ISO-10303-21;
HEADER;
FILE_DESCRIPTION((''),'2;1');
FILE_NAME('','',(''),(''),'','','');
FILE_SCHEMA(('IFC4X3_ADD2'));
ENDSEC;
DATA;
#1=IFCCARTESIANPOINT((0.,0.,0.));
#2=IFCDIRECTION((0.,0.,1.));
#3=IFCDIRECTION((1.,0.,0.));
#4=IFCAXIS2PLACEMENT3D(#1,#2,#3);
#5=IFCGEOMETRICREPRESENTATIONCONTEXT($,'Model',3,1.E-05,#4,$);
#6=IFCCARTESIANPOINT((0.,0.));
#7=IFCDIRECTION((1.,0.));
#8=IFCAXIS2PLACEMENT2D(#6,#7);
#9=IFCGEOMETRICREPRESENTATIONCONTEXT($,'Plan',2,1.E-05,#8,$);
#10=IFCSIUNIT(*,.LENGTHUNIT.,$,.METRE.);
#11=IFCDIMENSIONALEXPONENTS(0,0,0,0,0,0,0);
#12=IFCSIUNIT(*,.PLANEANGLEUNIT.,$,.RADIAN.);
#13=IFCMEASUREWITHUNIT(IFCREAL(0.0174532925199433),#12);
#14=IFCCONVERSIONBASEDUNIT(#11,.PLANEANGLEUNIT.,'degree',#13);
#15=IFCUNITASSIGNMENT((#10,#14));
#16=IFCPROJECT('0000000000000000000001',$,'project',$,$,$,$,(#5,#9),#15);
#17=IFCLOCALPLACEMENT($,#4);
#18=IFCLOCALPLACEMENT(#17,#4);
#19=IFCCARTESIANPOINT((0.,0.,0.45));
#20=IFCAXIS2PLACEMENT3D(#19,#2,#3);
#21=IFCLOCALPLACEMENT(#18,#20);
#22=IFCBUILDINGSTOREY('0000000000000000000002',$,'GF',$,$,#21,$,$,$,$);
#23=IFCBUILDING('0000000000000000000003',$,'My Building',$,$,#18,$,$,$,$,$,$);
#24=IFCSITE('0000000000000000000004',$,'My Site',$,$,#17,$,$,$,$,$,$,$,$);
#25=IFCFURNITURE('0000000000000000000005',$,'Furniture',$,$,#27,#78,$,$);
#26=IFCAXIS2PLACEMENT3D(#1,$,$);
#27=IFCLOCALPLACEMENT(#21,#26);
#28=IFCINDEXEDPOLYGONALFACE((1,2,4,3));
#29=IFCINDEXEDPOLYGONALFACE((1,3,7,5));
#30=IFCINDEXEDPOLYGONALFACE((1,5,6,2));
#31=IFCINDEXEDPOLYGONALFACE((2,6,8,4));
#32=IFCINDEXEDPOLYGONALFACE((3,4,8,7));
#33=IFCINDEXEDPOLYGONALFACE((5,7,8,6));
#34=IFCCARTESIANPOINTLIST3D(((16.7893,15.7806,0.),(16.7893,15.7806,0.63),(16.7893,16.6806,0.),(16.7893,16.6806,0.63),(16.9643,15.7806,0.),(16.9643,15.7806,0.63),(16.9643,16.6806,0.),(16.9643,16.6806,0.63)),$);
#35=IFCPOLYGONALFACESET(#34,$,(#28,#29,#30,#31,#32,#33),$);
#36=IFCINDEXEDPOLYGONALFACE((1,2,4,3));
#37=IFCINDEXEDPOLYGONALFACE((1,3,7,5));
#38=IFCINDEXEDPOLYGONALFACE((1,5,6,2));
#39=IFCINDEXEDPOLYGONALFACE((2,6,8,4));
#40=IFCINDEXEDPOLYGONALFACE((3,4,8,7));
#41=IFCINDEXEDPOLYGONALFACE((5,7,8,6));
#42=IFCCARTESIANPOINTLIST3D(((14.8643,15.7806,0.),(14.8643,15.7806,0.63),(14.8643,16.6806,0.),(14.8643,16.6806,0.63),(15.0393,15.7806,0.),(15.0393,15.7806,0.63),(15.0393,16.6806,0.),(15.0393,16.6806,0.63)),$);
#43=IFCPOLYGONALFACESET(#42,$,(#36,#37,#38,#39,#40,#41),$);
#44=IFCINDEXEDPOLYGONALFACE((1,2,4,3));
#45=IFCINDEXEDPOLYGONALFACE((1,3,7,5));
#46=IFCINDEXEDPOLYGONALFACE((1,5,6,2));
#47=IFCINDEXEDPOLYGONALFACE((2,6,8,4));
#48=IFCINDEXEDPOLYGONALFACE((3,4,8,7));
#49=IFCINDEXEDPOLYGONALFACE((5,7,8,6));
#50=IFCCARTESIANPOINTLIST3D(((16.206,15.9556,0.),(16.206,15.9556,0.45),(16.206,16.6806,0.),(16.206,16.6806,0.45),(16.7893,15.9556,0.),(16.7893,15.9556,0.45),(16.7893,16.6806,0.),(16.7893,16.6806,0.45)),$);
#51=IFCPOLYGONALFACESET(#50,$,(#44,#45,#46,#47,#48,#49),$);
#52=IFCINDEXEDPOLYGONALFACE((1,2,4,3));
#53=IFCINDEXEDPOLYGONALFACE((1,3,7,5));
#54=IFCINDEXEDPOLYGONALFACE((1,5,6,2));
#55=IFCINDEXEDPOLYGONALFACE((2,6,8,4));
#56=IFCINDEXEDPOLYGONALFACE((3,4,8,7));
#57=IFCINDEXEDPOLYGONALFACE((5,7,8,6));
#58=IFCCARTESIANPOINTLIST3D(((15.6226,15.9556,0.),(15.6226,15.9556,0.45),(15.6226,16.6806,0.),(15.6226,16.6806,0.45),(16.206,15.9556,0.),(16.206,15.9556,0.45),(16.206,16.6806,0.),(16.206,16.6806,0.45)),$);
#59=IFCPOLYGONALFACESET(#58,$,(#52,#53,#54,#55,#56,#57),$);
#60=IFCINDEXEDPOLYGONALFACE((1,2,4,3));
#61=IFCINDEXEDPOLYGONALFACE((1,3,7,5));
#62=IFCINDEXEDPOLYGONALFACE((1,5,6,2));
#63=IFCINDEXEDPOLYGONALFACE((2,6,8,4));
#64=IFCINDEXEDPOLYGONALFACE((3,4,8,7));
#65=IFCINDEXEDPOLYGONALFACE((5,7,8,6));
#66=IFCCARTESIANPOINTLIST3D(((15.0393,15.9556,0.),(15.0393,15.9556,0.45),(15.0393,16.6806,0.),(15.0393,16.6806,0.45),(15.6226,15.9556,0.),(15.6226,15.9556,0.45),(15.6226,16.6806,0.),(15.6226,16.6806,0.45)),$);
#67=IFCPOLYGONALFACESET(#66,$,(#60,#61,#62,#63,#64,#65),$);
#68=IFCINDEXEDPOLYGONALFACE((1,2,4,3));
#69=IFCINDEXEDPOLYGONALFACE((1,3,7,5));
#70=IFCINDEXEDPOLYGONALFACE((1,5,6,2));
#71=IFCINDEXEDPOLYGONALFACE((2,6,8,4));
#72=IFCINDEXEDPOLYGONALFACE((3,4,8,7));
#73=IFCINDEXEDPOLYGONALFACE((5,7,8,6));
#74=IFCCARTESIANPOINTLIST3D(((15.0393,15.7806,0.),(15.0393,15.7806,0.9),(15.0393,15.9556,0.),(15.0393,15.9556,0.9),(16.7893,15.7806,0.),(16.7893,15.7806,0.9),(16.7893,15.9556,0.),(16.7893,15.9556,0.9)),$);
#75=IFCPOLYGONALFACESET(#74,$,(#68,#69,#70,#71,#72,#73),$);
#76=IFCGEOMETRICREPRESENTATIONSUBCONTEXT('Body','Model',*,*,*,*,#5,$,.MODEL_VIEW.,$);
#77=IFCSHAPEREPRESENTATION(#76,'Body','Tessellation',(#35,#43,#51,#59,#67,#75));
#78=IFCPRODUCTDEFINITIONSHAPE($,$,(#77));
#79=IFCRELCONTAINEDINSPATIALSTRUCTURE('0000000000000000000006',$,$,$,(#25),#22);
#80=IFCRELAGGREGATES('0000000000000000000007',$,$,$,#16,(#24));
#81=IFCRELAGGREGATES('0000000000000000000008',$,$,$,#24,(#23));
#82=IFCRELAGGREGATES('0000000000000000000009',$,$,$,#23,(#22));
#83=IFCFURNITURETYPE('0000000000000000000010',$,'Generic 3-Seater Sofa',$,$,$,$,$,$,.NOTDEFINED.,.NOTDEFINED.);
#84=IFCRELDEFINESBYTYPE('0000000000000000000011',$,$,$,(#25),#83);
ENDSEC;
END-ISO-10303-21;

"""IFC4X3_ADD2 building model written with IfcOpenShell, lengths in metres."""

from ifc_helpers import new_model, entity, si_unit, converted_unit, frame, origin_with_axes, origin_2d_with_axis, place, context, subcontext, project, spatial, line, indexed_curve, outline, extrude, shape, source, transform, mapped, type_object, type_shapes, element, save


model = new_model("IFC4X3_ADD2")

# Units and contexts
model_context = context("Model", 3, precision=1e-05, world=origin_with_axes())
plan_context = context("Plan", 2, precision=1e-05, world=origin_2d_with_axis())
body_context_1 = subcontext(model_context, "Body", "Model", "MODEL_VIEW")
body_context_2 = subcontext(plan_context, "Body", "Plan", "PLAN_VIEW")
ifc_project = project(units=[si_unit("LENGTHUNIT", "METRE"), converted_unit("PLANEANGLEUNIT", "degree", entity("IfcReal", 0.0174532925199433), si_unit("PLANEANGLEUNIT", "RADIAN"), dimensions=[0, 0, 0, 0, 0, 0, 0])], contexts=[model_context, plan_context])

# Site, building, storey
site_placement = place(None, origin_with_axes())
site = spatial("IfcSite", under=ifc_project, at=site_placement, Name="My Site")
building_placement = place(site_placement, origin_with_axes())
building = spatial("IfcBuilding", under=site, at=building_placement, Name="My Building")
storey_placement = place(building_placement, frame((0.0, 0.0, 0.45), z_axis=(0.0, 0.0, 1.0), x_axis=(1.0, 0.0, 0.0)))
storey = spatial("IfcBuildingStorey", under=building, at=storey_placement, Name="GF")

# Furniture
furniture_type = type_object("IfcFurnitureType", Name="Generic 3-Seater Sofa", AssemblyPlace="NOTDEFINED", PredefinedType="NOTDEFINED")
shared_shape_1 = source(origin_with_axes(), body_context_1, "Body", "SweptSolid", [
    extrude(outline(indexed_curve([(0.0, 0.0), (0.175, 0.0), (0.175, 0.9), (0.0, 0.9)], segments=[line(1, 2, 3, 4, 1)])), frame((-1.05, -0.9, 0.0), z_axis=(0.0, 0.0, 1.0), x_axis=(1.0, 0.0, 0.0)), (0.0, 0.0, 1.0), 0.63),
    extrude(outline(indexed_curve([(0.0, 0.0), (0.175, 0.0), (0.175, 0.9), (0.0, 0.9)], segments=[line(1, 2, 3, 4, 1)])), frame((0.875, -0.9, 0.0), z_axis=(0.0, 0.0, 1.0), x_axis=(1.0, 0.0, 0.0)), (0.0, 0.0, 1.0), 0.63),
    extrude(outline(indexed_curve([(0.175, 0.0), (0.7583, 0.0), (0.7583, 0.725), (0.175, 0.725)], segments=[line(1, 2, 3, 4, 1)])), frame((-1.05, -0.9, 0.0), z_axis=(0.0, 0.0, 1.0), x_axis=(1.0, 0.0, 0.0)), (0.0, 0.0, 1.0), 0.45),
    extrude(outline(indexed_curve([(0.7583, 0.0), (1.3417, 0.0), (1.3417, 0.725), (0.7583, 0.725)], segments=[line(1, 2, 3, 4, 1)])), frame((-1.05, -0.9, 0.0), z_axis=(0.0, 0.0, 1.0), x_axis=(1.0, 0.0, 0.0)), (0.0, 0.0, 1.0), 0.45),
    extrude(outline(indexed_curve([(1.3417, 0.0), (1.925, 0.0), (1.925, 0.725), (1.3417, 0.725)], segments=[line(1, 2, 3, 4, 1)])), frame((-1.05, -0.9, 0.0), z_axis=(0.0, 0.0, 1.0), x_axis=(1.0, 0.0, 0.0)), (0.0, 0.0, 1.0), 0.45),
    extrude(outline(indexed_curve([(0.175, 0.725), (1.925, 0.725), (1.925, 0.9), (0.175, 0.9)], segments=[line(1, 2, 3, 4, 1)])), frame((-1.05, -0.9, 0.0), z_axis=(0.0, 0.0, 1.0), x_axis=(1.0, 0.0, 0.0)), (0.0, 0.0, 1.0), 0.9),
])
shared_shape_2 = source(origin_with_axes(), body_context_2, "Body", "Curve2D", [
    entity("IfcIndexedPolyCurve", entity("IfcCartesianPointList2D", [[-1.05, -0.9], [-0.875, -0.9], [-0.875, 0.0], [-1.05, 0.0]]), [entity("IfcLineIndex", [1, 2, 3, 4, 1])]),
    entity("IfcIndexedPolyCurve", entity("IfcCartesianPointList2D", [[0.875, -0.9], [1.05, -0.9], [1.05, 0.0], [0.875, 0.0]]), [entity("IfcLineIndex", [1, 2, 3, 4, 1])]),
    entity("IfcIndexedPolyCurve", entity("IfcCartesianPointList2D", [[-0.875, -0.9], [-0.2917, -0.9], [-0.2917, -0.175], [-0.875, -0.175]]), [entity("IfcLineIndex", [1, 2, 3, 4, 1])]),
    entity("IfcIndexedPolyCurve", entity("IfcCartesianPointList2D", [[-0.2917, -0.9], [0.2917, -0.9], [0.2917, -0.175], [-0.2917, -0.175]]), [entity("IfcLineIndex", [1, 2, 3, 4, 1])]),
    entity("IfcIndexedPolyCurve", entity("IfcCartesianPointList2D", [[0.2917, -0.9], [0.875, -0.9], [0.875, -0.175], [0.2917, -0.175]]), [entity("IfcLineIndex", [1, 2, 3, 4, 1])]),
    entity("IfcIndexedPolyCurve", entity("IfcCartesianPointList2D", [[-0.875, -0.175], [0.875, -0.175], [0.875, 0.0], [-0.875, 0.0]]), [entity("IfcLineIndex", [1, 2, 3, 4, 1])]),
])
type_shapes(furniture_type, [shared_shape_1, shared_shape_2])
furniture_placement = place(storey_placement, frame((15.9143, 15.7806, 0.0), z_axis=(0.0, 0.0, 1.0), x_axis=(-1.0, 0.0, 0.0)))
element("IfcFurniture", 1, at=furniture_placement, inside=storey, type_object=furniture_type, Name="Furniture", shapes=[
    shape(body_context_1, "Body", "MappedRepresentation", [mapped(shared_shape_1, transform((0.0, 0.0, 0.0), x_axis=(1.0, 0.0, 0.0), y_axis=(0.0, 1.0, 0.0), z_axis=(0.0, 0.0, 1.0), scale=1.0))]),
    shape(body_context_2, "Body", "MappedRepresentation", [mapped(shared_shape_2, transform((0.0, 0.0, 0.0), x_axis=(1.0, 0.0, 0.0), y_axis=(0.0, 1.0, 0.0), z_axis=(0.0, 0.0, 1.0), scale=1.0))]),
])

save(model, "model.ifc")
